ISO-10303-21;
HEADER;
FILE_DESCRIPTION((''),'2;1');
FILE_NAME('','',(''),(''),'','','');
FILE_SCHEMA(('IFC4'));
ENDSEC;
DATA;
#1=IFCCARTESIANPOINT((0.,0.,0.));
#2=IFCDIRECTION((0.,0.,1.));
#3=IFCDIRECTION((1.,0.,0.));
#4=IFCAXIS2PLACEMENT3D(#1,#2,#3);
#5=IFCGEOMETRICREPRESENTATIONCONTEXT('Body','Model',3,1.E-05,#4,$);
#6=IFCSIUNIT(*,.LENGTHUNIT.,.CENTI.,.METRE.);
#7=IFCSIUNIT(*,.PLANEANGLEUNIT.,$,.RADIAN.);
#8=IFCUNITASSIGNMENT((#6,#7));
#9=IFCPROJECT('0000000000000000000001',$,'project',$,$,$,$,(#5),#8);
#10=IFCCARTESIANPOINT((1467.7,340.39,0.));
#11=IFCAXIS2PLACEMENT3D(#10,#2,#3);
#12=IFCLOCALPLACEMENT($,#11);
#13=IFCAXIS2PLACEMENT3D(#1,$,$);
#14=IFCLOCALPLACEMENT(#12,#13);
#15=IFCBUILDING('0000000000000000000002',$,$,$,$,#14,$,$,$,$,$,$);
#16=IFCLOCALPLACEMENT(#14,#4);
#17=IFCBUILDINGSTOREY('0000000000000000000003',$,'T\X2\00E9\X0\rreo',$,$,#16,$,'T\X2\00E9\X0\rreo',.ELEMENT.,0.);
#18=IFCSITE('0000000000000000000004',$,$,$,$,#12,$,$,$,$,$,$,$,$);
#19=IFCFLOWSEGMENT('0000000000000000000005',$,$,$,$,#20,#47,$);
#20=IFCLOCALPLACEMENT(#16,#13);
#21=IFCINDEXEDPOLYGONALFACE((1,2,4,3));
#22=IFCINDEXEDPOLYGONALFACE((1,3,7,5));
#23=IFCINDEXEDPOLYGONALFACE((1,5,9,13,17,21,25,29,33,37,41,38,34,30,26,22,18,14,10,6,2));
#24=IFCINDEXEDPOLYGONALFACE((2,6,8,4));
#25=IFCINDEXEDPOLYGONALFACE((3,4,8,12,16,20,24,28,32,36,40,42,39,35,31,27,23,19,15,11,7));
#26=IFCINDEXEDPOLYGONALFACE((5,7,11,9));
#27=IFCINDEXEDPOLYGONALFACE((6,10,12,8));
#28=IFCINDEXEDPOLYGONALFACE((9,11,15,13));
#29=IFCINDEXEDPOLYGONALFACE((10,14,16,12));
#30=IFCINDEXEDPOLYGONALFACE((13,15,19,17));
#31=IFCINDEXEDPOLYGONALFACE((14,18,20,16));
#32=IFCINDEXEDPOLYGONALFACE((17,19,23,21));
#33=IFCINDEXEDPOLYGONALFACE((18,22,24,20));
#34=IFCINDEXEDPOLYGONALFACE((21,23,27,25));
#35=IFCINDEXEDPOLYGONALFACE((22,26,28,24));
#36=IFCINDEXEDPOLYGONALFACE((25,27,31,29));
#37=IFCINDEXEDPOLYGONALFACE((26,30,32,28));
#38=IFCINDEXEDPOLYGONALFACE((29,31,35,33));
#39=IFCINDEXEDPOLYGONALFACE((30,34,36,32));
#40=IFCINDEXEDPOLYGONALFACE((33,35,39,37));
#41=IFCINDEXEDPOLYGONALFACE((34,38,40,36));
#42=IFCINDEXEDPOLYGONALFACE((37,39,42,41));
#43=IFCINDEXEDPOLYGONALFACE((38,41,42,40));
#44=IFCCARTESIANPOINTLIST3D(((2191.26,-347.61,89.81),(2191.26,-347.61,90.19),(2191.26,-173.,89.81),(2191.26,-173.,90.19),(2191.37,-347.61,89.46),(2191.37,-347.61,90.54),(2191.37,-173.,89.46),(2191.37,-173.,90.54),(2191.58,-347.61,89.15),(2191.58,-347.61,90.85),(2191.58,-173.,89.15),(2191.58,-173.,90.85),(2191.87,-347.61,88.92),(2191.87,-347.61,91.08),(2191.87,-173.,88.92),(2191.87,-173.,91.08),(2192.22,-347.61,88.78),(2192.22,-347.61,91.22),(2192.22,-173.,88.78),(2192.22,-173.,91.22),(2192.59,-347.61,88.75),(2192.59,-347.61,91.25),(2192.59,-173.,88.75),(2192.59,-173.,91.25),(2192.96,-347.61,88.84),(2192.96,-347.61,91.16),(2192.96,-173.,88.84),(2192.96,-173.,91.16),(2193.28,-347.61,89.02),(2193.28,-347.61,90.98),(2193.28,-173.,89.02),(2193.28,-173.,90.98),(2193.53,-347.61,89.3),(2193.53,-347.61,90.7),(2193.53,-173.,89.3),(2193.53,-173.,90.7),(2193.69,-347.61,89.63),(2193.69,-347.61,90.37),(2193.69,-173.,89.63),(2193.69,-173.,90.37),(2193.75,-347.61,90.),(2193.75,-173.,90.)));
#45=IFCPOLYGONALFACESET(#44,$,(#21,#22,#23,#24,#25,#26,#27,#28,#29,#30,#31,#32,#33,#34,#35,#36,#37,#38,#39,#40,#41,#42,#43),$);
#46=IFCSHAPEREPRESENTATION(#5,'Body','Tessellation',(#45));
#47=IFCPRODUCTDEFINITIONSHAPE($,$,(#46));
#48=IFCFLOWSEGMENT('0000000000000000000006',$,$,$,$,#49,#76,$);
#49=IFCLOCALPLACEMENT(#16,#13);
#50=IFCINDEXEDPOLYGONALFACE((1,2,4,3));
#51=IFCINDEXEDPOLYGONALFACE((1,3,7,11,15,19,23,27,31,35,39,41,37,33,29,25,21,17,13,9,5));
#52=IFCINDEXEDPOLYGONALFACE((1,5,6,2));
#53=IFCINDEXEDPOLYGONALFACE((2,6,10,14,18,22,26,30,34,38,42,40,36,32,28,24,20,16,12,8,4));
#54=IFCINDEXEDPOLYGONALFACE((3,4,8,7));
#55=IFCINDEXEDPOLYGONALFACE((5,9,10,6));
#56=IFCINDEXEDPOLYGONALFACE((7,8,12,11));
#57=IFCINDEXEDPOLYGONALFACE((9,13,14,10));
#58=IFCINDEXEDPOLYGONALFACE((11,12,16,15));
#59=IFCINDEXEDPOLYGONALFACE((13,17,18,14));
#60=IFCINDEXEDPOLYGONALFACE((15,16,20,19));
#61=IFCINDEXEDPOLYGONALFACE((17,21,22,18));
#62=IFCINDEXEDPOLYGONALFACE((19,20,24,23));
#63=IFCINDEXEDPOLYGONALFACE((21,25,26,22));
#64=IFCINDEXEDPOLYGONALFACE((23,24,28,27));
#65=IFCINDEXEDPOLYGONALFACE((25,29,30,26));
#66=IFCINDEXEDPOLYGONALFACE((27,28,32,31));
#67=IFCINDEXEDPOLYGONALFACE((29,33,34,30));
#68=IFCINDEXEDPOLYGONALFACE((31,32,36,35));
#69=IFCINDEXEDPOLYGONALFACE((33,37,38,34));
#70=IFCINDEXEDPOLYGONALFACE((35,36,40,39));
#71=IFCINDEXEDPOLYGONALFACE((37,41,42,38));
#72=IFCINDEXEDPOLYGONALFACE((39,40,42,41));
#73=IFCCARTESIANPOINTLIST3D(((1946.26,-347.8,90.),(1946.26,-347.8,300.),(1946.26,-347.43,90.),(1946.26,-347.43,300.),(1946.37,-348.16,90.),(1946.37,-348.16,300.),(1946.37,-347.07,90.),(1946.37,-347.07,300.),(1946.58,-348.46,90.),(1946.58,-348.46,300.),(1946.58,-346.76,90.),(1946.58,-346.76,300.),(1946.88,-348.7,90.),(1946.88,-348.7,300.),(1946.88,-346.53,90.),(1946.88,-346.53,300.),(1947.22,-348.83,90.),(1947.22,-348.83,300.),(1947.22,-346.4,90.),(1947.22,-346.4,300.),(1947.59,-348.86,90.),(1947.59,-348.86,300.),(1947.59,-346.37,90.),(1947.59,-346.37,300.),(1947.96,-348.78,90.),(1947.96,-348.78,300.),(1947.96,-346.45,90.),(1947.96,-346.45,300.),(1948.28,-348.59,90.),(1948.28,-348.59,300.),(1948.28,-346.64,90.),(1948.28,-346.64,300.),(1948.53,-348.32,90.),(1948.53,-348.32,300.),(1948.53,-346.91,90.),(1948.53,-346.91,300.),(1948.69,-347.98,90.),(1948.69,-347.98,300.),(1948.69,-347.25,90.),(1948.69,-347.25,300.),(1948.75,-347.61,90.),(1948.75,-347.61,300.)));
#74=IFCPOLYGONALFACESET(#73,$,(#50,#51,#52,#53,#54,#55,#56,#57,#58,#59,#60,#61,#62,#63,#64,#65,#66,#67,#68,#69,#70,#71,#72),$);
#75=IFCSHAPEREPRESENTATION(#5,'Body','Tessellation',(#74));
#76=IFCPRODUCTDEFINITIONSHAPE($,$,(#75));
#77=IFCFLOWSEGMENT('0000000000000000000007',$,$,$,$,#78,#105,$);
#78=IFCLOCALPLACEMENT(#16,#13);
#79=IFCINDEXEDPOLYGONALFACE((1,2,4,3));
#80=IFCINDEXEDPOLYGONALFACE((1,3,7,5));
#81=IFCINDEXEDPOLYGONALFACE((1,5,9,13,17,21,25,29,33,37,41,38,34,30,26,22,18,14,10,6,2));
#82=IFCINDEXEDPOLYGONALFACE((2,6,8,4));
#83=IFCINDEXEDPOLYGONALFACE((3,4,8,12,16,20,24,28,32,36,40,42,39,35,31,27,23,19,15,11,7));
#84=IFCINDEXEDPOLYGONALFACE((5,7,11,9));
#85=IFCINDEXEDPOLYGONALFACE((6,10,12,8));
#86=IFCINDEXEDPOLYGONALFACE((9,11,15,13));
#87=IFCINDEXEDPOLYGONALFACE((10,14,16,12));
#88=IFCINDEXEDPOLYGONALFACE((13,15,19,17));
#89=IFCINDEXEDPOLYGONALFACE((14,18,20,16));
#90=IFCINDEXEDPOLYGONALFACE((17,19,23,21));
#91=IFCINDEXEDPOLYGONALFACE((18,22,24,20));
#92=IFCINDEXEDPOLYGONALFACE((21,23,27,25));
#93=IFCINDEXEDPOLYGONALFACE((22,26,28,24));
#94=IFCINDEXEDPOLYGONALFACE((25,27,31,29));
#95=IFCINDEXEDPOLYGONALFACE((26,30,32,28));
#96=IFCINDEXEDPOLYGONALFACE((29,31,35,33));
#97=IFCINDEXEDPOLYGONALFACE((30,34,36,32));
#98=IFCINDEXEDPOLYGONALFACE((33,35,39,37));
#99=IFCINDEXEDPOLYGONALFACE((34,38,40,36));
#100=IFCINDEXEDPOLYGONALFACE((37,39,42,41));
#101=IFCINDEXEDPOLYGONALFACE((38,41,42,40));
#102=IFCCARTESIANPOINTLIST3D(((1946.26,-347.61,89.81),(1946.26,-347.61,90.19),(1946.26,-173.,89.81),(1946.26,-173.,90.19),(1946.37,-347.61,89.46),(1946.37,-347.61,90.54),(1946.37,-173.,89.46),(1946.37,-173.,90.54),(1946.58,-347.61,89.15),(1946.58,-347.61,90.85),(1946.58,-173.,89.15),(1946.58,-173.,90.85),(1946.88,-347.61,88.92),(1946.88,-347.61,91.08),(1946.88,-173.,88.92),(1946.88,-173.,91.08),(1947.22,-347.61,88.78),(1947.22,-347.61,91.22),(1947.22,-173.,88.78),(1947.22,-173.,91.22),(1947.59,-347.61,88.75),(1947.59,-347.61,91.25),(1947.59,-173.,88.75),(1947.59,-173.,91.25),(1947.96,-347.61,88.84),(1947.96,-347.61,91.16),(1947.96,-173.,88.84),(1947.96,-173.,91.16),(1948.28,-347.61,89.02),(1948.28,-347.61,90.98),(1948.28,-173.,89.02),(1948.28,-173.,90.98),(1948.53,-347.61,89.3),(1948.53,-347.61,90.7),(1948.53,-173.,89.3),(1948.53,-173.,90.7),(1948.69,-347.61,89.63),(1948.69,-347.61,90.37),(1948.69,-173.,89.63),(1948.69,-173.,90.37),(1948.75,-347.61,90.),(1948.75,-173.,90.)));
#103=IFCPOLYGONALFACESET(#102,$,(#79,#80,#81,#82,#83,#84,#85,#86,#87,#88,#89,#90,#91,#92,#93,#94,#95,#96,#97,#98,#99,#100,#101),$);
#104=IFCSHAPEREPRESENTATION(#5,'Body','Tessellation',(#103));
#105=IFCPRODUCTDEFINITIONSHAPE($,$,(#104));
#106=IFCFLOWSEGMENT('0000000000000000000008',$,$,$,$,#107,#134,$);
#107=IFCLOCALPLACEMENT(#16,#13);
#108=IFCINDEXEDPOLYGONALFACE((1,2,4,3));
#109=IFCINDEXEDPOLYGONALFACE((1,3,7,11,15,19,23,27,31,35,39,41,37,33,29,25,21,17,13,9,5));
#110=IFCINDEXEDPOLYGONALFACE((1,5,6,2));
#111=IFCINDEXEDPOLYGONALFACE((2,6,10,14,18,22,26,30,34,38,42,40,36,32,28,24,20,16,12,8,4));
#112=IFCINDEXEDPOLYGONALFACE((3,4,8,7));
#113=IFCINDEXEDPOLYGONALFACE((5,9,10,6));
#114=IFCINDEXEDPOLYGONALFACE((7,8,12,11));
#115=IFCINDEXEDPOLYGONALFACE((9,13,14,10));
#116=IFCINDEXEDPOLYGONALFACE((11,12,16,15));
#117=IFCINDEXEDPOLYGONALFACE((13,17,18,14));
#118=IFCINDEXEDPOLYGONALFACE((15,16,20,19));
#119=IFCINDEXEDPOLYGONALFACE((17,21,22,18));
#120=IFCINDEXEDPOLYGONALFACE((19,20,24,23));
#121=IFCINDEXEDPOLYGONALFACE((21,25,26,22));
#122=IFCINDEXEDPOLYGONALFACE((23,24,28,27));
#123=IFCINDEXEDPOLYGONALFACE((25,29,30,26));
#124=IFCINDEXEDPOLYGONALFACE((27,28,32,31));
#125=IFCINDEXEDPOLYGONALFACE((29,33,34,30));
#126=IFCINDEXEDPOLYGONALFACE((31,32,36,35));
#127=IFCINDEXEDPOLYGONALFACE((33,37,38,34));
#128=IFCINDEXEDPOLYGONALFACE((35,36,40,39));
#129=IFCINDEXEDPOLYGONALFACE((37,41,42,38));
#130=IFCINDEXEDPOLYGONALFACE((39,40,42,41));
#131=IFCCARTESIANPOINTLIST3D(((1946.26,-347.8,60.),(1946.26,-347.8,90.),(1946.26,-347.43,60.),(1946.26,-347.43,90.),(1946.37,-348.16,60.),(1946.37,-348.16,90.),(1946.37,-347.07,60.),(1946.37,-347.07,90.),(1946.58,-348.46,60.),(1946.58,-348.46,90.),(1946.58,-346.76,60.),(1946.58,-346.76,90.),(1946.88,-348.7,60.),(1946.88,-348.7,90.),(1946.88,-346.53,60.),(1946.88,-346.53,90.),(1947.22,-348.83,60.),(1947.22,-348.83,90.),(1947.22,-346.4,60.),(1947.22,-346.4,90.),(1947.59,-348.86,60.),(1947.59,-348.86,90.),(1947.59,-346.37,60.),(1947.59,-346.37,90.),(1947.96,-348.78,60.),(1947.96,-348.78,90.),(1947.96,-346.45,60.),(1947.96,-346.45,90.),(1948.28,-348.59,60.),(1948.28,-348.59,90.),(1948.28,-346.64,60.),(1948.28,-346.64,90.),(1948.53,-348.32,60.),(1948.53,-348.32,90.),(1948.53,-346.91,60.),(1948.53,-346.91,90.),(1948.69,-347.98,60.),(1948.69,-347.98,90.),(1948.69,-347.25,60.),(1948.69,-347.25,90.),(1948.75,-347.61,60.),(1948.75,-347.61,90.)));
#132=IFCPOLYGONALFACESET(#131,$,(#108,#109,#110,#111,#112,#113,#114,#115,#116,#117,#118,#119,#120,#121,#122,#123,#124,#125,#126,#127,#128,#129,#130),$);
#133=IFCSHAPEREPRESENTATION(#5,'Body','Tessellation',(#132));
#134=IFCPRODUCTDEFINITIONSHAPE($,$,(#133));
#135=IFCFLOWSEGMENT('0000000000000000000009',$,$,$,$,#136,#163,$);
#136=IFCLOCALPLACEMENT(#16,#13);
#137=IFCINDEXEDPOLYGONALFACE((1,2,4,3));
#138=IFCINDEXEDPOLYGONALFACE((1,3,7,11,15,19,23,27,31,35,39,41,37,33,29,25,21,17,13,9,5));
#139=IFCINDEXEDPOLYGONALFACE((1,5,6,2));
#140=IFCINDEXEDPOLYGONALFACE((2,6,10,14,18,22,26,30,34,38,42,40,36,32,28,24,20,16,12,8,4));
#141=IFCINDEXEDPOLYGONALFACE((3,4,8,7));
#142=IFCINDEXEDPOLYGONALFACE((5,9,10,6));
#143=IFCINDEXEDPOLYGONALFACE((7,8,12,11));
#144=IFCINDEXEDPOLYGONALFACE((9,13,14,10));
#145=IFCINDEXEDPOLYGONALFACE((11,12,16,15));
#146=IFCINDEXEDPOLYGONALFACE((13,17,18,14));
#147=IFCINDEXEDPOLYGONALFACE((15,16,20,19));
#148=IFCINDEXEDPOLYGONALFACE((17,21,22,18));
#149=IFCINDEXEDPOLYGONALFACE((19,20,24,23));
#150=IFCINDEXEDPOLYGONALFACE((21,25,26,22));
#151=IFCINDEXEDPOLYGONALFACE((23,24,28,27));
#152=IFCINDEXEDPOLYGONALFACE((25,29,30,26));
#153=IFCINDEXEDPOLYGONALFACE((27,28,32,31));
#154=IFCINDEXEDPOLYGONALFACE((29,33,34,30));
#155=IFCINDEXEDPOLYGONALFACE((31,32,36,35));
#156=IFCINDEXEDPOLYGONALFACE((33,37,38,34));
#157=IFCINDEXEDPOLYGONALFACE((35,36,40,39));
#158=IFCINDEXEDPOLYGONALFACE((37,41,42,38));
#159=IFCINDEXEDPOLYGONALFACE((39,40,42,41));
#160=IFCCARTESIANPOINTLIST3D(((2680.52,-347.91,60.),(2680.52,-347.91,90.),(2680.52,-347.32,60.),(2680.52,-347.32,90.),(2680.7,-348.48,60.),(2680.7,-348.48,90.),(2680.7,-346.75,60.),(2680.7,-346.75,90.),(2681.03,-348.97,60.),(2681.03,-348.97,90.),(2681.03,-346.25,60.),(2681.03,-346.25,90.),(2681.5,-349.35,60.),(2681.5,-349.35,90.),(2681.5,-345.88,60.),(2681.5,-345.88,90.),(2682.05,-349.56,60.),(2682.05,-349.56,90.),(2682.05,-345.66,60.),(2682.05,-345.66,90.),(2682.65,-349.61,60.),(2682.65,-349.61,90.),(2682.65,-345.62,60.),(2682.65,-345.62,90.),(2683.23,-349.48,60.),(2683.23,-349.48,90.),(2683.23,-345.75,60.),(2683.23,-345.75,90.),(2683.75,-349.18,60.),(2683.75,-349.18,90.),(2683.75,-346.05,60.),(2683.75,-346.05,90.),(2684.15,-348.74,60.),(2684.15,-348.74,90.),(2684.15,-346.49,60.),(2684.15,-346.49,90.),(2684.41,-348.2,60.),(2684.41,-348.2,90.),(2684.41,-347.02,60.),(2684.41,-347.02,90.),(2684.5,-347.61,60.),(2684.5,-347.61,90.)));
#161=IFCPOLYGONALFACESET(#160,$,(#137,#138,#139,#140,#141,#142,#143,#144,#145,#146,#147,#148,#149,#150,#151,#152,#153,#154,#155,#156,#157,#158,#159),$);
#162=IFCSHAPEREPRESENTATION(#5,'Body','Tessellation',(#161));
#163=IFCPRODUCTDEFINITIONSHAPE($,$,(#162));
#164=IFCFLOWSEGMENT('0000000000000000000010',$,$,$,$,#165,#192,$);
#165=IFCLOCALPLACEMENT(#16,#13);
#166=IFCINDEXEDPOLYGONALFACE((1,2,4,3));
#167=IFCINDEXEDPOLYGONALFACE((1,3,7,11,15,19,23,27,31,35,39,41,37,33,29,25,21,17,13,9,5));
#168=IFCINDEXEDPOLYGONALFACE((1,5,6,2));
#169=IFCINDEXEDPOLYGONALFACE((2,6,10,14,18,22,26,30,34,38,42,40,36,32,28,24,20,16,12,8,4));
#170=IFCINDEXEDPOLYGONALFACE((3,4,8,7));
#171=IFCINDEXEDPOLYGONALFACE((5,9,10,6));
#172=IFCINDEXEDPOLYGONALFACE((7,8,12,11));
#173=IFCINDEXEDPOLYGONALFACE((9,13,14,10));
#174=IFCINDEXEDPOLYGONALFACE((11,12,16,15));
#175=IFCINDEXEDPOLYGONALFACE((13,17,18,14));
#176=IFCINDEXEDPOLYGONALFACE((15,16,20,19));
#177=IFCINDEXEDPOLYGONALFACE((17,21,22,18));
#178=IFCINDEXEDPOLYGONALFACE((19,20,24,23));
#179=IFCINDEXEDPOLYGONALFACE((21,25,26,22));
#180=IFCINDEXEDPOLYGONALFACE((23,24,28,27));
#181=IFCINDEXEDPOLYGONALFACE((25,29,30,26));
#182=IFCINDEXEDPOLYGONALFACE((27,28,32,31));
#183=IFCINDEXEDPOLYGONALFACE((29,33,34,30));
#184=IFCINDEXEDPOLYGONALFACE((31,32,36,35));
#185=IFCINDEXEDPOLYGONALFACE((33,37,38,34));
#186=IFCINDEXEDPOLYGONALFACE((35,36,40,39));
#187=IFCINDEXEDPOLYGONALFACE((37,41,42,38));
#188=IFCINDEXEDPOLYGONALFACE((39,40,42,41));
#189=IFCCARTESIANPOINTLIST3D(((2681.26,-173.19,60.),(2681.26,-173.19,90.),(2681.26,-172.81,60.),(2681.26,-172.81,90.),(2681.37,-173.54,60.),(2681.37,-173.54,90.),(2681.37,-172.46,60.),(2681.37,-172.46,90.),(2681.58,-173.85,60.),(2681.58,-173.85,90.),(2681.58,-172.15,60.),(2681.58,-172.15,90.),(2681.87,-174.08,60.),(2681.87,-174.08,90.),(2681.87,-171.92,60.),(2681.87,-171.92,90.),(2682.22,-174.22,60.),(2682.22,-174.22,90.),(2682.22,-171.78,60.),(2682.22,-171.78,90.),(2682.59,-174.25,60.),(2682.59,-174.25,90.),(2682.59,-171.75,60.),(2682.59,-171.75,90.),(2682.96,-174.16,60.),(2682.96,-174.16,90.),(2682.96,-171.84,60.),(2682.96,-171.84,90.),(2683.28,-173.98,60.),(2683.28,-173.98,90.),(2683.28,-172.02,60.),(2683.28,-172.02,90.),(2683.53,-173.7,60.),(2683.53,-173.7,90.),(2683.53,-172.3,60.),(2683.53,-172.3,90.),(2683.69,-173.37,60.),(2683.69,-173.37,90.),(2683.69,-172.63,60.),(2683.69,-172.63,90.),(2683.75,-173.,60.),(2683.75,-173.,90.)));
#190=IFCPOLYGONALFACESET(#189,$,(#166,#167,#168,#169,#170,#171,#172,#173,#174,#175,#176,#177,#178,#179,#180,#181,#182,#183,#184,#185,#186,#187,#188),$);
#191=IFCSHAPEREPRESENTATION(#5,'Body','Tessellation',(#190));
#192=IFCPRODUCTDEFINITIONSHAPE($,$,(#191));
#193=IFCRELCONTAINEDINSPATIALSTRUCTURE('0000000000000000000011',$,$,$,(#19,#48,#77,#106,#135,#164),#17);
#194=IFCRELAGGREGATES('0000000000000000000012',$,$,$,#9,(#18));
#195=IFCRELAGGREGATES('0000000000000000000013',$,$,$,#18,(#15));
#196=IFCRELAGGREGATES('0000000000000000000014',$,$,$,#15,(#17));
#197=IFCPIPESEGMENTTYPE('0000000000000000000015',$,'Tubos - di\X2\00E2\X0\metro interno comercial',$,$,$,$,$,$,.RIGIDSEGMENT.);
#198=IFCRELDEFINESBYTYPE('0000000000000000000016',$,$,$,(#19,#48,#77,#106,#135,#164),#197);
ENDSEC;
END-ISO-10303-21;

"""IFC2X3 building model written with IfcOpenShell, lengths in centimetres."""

from ifc_helpers import new_model, si_unit, frame, origin, origin_with_axes, origin_2d_with_axis, place, context, project, spatial, circle, extrude, type_object, element, save


model = new_model("IFC2X3")

# Units and contexts
model_context = context("Model", 3, precision=1e-05, world=origin_with_axes(), identifier="Body")
ifc_project = project(units=[si_unit("LENGTHUNIT", "METRE", prefix="CENTI"), si_unit("PLANEANGLEUNIT", "RADIAN")], contexts=[model_context])

# Site, building, storey
site_placement = place(None, frame((1467.7, 340.39, 0.0), z_axis=(0.0, 0.0, 1.0), x_axis=(1.0, 0.0, 0.0)))
site = spatial("IfcSite", under=ifc_project, at=site_placement)
building_placement = place(site_placement, origin())
building = spatial("IfcBuilding", under=site, at=building_placement)
storey_placement = place(building_placement, origin_with_axes())
storey = spatial("IfcBuildingStorey", under=building, at=storey_placement, Name="Térreo", LongName="Térreo", CompositionType="ELEMENT", Elevation=0.0)

# Flow segments
pipe_segment_type_1 = type_object("IfcPipeSegmentType", Name="Tubos - diâmetro interno comercial", PredefinedType="RIGIDSEGMENT")
flow_segment_1_placement = place(storey_placement, frame((2192.5, -260.31, 91.25), z_axis=(0.0, 0.0, 1.0), x_axis=(1.0, 0.0, 0.0)))
element("IfcFlowSegment", 1, at=flow_segment_1_placement, inside=storey, type_object=pipe_segment_type_1, context=model_context, shape_type="SolidModel", body=[
    extrude(circle(Radius=1.25, at=origin_2d_with_axis()), frame((0.0, -87.31, -1.25), z_axis=(0.0, 1.0, 0.0), x_axis=(1.0, 0.0, 0.0)), (0.0, 0.0, 1.0), 174.61),
])
flow_segment_2_placement = place(storey_placement, frame((1947.5, -347.61, 300.0), z_axis=(0.0, 0.0, 1.0), x_axis=(1.0, 0.0, 0.0)))
element("IfcFlowSegment", 2, at=flow_segment_2_placement, inside=storey, type_object=pipe_segment_type_1, context=model_context, shape_type="SolidModel", body=[
    extrude(circle(Radius=1.25, at=origin_2d_with_axis()), frame((0.0, 0.0, 0.0), z_axis=(0.0, 0.0, -1.0), x_axis=(1.0, 0.0, 0.0)), (0.0, 0.0, 1.0), 210.0),
])
flow_segment_3_placement = place(storey_placement, frame((1947.5, -260.31, 91.25), z_axis=(0.0, 0.0, 1.0), x_axis=(1.0, 0.0, 0.0)))
element("IfcFlowSegment", 3, at=flow_segment_3_placement, inside=storey, type_object=pipe_segment_type_1, context=model_context, shape_type="SolidModel", body=[
    extrude(circle(Radius=1.25, at=origin_2d_with_axis()), frame((0.0, -87.31, -1.25), z_axis=(0.0, 1.0, 0.0), x_axis=(1.0, 0.0, 0.0)), (0.0, 0.0, 1.0), 174.61),
])
flow_segment_4_placement = place(storey_placement, frame((1947.5, -347.61, 90.0), z_axis=(0.0, 0.0, 1.0), x_axis=(1.0, 0.0, 0.0)))
element("IfcFlowSegment", 4, at=flow_segment_4_placement, inside=storey, type_object=pipe_segment_type_1, context=model_context, shape_type="SolidModel", body=[
    extrude(circle(Radius=1.25, at=origin_2d_with_axis()), frame((0.0, 0.0, 0.0), z_axis=(0.0, 0.0, -1.0), x_axis=(1.0, 0.0, 0.0)), (0.0, 0.0, 1.0), 30.0),
])
flow_segment_5_placement = place(storey_placement, frame((2682.5, -347.61, 90.0), z_axis=(0.0, 0.0, 1.0), x_axis=(1.0, 0.0, 0.0)))
element("IfcFlowSegment", 5, at=flow_segment_5_placement, inside=storey, type_object=pipe_segment_type_1, context=model_context, shape_type="SolidModel", body=[
    extrude(circle(Radius=2.0, at=origin_2d_with_axis()), frame((0.0, 0.0, 0.0), z_axis=(0.0, 0.0, -1.0), x_axis=(1.0, 0.0, 0.0)), (0.0, 0.0, 1.0), 30.0),
])
for number, where, z_axis, x_axis in (
    (6, (2682.5, -173.0, 90.0), (0.0, 0.0, 1.0), (1.0, 0.0, 0.0)),
):
    element("IfcFlowSegment", number, at=place(storey_placement, frame(where, z_axis=z_axis, x_axis=x_axis)), inside=storey, type_object=pipe_segment_type_1, context=model_context, shape_type="SolidModel", body=[
        extrude(circle(Radius=1.25, at=origin_2d_with_axis()), frame((0.0, 0.0, 0.0), z_axis=(0.0, 0.0, -1.0), x_axis=(1.0, 0.0, 0.0)), (0.0, 0.0, 1.0), 30.0),
    ])

save(model, "model.ifc")
